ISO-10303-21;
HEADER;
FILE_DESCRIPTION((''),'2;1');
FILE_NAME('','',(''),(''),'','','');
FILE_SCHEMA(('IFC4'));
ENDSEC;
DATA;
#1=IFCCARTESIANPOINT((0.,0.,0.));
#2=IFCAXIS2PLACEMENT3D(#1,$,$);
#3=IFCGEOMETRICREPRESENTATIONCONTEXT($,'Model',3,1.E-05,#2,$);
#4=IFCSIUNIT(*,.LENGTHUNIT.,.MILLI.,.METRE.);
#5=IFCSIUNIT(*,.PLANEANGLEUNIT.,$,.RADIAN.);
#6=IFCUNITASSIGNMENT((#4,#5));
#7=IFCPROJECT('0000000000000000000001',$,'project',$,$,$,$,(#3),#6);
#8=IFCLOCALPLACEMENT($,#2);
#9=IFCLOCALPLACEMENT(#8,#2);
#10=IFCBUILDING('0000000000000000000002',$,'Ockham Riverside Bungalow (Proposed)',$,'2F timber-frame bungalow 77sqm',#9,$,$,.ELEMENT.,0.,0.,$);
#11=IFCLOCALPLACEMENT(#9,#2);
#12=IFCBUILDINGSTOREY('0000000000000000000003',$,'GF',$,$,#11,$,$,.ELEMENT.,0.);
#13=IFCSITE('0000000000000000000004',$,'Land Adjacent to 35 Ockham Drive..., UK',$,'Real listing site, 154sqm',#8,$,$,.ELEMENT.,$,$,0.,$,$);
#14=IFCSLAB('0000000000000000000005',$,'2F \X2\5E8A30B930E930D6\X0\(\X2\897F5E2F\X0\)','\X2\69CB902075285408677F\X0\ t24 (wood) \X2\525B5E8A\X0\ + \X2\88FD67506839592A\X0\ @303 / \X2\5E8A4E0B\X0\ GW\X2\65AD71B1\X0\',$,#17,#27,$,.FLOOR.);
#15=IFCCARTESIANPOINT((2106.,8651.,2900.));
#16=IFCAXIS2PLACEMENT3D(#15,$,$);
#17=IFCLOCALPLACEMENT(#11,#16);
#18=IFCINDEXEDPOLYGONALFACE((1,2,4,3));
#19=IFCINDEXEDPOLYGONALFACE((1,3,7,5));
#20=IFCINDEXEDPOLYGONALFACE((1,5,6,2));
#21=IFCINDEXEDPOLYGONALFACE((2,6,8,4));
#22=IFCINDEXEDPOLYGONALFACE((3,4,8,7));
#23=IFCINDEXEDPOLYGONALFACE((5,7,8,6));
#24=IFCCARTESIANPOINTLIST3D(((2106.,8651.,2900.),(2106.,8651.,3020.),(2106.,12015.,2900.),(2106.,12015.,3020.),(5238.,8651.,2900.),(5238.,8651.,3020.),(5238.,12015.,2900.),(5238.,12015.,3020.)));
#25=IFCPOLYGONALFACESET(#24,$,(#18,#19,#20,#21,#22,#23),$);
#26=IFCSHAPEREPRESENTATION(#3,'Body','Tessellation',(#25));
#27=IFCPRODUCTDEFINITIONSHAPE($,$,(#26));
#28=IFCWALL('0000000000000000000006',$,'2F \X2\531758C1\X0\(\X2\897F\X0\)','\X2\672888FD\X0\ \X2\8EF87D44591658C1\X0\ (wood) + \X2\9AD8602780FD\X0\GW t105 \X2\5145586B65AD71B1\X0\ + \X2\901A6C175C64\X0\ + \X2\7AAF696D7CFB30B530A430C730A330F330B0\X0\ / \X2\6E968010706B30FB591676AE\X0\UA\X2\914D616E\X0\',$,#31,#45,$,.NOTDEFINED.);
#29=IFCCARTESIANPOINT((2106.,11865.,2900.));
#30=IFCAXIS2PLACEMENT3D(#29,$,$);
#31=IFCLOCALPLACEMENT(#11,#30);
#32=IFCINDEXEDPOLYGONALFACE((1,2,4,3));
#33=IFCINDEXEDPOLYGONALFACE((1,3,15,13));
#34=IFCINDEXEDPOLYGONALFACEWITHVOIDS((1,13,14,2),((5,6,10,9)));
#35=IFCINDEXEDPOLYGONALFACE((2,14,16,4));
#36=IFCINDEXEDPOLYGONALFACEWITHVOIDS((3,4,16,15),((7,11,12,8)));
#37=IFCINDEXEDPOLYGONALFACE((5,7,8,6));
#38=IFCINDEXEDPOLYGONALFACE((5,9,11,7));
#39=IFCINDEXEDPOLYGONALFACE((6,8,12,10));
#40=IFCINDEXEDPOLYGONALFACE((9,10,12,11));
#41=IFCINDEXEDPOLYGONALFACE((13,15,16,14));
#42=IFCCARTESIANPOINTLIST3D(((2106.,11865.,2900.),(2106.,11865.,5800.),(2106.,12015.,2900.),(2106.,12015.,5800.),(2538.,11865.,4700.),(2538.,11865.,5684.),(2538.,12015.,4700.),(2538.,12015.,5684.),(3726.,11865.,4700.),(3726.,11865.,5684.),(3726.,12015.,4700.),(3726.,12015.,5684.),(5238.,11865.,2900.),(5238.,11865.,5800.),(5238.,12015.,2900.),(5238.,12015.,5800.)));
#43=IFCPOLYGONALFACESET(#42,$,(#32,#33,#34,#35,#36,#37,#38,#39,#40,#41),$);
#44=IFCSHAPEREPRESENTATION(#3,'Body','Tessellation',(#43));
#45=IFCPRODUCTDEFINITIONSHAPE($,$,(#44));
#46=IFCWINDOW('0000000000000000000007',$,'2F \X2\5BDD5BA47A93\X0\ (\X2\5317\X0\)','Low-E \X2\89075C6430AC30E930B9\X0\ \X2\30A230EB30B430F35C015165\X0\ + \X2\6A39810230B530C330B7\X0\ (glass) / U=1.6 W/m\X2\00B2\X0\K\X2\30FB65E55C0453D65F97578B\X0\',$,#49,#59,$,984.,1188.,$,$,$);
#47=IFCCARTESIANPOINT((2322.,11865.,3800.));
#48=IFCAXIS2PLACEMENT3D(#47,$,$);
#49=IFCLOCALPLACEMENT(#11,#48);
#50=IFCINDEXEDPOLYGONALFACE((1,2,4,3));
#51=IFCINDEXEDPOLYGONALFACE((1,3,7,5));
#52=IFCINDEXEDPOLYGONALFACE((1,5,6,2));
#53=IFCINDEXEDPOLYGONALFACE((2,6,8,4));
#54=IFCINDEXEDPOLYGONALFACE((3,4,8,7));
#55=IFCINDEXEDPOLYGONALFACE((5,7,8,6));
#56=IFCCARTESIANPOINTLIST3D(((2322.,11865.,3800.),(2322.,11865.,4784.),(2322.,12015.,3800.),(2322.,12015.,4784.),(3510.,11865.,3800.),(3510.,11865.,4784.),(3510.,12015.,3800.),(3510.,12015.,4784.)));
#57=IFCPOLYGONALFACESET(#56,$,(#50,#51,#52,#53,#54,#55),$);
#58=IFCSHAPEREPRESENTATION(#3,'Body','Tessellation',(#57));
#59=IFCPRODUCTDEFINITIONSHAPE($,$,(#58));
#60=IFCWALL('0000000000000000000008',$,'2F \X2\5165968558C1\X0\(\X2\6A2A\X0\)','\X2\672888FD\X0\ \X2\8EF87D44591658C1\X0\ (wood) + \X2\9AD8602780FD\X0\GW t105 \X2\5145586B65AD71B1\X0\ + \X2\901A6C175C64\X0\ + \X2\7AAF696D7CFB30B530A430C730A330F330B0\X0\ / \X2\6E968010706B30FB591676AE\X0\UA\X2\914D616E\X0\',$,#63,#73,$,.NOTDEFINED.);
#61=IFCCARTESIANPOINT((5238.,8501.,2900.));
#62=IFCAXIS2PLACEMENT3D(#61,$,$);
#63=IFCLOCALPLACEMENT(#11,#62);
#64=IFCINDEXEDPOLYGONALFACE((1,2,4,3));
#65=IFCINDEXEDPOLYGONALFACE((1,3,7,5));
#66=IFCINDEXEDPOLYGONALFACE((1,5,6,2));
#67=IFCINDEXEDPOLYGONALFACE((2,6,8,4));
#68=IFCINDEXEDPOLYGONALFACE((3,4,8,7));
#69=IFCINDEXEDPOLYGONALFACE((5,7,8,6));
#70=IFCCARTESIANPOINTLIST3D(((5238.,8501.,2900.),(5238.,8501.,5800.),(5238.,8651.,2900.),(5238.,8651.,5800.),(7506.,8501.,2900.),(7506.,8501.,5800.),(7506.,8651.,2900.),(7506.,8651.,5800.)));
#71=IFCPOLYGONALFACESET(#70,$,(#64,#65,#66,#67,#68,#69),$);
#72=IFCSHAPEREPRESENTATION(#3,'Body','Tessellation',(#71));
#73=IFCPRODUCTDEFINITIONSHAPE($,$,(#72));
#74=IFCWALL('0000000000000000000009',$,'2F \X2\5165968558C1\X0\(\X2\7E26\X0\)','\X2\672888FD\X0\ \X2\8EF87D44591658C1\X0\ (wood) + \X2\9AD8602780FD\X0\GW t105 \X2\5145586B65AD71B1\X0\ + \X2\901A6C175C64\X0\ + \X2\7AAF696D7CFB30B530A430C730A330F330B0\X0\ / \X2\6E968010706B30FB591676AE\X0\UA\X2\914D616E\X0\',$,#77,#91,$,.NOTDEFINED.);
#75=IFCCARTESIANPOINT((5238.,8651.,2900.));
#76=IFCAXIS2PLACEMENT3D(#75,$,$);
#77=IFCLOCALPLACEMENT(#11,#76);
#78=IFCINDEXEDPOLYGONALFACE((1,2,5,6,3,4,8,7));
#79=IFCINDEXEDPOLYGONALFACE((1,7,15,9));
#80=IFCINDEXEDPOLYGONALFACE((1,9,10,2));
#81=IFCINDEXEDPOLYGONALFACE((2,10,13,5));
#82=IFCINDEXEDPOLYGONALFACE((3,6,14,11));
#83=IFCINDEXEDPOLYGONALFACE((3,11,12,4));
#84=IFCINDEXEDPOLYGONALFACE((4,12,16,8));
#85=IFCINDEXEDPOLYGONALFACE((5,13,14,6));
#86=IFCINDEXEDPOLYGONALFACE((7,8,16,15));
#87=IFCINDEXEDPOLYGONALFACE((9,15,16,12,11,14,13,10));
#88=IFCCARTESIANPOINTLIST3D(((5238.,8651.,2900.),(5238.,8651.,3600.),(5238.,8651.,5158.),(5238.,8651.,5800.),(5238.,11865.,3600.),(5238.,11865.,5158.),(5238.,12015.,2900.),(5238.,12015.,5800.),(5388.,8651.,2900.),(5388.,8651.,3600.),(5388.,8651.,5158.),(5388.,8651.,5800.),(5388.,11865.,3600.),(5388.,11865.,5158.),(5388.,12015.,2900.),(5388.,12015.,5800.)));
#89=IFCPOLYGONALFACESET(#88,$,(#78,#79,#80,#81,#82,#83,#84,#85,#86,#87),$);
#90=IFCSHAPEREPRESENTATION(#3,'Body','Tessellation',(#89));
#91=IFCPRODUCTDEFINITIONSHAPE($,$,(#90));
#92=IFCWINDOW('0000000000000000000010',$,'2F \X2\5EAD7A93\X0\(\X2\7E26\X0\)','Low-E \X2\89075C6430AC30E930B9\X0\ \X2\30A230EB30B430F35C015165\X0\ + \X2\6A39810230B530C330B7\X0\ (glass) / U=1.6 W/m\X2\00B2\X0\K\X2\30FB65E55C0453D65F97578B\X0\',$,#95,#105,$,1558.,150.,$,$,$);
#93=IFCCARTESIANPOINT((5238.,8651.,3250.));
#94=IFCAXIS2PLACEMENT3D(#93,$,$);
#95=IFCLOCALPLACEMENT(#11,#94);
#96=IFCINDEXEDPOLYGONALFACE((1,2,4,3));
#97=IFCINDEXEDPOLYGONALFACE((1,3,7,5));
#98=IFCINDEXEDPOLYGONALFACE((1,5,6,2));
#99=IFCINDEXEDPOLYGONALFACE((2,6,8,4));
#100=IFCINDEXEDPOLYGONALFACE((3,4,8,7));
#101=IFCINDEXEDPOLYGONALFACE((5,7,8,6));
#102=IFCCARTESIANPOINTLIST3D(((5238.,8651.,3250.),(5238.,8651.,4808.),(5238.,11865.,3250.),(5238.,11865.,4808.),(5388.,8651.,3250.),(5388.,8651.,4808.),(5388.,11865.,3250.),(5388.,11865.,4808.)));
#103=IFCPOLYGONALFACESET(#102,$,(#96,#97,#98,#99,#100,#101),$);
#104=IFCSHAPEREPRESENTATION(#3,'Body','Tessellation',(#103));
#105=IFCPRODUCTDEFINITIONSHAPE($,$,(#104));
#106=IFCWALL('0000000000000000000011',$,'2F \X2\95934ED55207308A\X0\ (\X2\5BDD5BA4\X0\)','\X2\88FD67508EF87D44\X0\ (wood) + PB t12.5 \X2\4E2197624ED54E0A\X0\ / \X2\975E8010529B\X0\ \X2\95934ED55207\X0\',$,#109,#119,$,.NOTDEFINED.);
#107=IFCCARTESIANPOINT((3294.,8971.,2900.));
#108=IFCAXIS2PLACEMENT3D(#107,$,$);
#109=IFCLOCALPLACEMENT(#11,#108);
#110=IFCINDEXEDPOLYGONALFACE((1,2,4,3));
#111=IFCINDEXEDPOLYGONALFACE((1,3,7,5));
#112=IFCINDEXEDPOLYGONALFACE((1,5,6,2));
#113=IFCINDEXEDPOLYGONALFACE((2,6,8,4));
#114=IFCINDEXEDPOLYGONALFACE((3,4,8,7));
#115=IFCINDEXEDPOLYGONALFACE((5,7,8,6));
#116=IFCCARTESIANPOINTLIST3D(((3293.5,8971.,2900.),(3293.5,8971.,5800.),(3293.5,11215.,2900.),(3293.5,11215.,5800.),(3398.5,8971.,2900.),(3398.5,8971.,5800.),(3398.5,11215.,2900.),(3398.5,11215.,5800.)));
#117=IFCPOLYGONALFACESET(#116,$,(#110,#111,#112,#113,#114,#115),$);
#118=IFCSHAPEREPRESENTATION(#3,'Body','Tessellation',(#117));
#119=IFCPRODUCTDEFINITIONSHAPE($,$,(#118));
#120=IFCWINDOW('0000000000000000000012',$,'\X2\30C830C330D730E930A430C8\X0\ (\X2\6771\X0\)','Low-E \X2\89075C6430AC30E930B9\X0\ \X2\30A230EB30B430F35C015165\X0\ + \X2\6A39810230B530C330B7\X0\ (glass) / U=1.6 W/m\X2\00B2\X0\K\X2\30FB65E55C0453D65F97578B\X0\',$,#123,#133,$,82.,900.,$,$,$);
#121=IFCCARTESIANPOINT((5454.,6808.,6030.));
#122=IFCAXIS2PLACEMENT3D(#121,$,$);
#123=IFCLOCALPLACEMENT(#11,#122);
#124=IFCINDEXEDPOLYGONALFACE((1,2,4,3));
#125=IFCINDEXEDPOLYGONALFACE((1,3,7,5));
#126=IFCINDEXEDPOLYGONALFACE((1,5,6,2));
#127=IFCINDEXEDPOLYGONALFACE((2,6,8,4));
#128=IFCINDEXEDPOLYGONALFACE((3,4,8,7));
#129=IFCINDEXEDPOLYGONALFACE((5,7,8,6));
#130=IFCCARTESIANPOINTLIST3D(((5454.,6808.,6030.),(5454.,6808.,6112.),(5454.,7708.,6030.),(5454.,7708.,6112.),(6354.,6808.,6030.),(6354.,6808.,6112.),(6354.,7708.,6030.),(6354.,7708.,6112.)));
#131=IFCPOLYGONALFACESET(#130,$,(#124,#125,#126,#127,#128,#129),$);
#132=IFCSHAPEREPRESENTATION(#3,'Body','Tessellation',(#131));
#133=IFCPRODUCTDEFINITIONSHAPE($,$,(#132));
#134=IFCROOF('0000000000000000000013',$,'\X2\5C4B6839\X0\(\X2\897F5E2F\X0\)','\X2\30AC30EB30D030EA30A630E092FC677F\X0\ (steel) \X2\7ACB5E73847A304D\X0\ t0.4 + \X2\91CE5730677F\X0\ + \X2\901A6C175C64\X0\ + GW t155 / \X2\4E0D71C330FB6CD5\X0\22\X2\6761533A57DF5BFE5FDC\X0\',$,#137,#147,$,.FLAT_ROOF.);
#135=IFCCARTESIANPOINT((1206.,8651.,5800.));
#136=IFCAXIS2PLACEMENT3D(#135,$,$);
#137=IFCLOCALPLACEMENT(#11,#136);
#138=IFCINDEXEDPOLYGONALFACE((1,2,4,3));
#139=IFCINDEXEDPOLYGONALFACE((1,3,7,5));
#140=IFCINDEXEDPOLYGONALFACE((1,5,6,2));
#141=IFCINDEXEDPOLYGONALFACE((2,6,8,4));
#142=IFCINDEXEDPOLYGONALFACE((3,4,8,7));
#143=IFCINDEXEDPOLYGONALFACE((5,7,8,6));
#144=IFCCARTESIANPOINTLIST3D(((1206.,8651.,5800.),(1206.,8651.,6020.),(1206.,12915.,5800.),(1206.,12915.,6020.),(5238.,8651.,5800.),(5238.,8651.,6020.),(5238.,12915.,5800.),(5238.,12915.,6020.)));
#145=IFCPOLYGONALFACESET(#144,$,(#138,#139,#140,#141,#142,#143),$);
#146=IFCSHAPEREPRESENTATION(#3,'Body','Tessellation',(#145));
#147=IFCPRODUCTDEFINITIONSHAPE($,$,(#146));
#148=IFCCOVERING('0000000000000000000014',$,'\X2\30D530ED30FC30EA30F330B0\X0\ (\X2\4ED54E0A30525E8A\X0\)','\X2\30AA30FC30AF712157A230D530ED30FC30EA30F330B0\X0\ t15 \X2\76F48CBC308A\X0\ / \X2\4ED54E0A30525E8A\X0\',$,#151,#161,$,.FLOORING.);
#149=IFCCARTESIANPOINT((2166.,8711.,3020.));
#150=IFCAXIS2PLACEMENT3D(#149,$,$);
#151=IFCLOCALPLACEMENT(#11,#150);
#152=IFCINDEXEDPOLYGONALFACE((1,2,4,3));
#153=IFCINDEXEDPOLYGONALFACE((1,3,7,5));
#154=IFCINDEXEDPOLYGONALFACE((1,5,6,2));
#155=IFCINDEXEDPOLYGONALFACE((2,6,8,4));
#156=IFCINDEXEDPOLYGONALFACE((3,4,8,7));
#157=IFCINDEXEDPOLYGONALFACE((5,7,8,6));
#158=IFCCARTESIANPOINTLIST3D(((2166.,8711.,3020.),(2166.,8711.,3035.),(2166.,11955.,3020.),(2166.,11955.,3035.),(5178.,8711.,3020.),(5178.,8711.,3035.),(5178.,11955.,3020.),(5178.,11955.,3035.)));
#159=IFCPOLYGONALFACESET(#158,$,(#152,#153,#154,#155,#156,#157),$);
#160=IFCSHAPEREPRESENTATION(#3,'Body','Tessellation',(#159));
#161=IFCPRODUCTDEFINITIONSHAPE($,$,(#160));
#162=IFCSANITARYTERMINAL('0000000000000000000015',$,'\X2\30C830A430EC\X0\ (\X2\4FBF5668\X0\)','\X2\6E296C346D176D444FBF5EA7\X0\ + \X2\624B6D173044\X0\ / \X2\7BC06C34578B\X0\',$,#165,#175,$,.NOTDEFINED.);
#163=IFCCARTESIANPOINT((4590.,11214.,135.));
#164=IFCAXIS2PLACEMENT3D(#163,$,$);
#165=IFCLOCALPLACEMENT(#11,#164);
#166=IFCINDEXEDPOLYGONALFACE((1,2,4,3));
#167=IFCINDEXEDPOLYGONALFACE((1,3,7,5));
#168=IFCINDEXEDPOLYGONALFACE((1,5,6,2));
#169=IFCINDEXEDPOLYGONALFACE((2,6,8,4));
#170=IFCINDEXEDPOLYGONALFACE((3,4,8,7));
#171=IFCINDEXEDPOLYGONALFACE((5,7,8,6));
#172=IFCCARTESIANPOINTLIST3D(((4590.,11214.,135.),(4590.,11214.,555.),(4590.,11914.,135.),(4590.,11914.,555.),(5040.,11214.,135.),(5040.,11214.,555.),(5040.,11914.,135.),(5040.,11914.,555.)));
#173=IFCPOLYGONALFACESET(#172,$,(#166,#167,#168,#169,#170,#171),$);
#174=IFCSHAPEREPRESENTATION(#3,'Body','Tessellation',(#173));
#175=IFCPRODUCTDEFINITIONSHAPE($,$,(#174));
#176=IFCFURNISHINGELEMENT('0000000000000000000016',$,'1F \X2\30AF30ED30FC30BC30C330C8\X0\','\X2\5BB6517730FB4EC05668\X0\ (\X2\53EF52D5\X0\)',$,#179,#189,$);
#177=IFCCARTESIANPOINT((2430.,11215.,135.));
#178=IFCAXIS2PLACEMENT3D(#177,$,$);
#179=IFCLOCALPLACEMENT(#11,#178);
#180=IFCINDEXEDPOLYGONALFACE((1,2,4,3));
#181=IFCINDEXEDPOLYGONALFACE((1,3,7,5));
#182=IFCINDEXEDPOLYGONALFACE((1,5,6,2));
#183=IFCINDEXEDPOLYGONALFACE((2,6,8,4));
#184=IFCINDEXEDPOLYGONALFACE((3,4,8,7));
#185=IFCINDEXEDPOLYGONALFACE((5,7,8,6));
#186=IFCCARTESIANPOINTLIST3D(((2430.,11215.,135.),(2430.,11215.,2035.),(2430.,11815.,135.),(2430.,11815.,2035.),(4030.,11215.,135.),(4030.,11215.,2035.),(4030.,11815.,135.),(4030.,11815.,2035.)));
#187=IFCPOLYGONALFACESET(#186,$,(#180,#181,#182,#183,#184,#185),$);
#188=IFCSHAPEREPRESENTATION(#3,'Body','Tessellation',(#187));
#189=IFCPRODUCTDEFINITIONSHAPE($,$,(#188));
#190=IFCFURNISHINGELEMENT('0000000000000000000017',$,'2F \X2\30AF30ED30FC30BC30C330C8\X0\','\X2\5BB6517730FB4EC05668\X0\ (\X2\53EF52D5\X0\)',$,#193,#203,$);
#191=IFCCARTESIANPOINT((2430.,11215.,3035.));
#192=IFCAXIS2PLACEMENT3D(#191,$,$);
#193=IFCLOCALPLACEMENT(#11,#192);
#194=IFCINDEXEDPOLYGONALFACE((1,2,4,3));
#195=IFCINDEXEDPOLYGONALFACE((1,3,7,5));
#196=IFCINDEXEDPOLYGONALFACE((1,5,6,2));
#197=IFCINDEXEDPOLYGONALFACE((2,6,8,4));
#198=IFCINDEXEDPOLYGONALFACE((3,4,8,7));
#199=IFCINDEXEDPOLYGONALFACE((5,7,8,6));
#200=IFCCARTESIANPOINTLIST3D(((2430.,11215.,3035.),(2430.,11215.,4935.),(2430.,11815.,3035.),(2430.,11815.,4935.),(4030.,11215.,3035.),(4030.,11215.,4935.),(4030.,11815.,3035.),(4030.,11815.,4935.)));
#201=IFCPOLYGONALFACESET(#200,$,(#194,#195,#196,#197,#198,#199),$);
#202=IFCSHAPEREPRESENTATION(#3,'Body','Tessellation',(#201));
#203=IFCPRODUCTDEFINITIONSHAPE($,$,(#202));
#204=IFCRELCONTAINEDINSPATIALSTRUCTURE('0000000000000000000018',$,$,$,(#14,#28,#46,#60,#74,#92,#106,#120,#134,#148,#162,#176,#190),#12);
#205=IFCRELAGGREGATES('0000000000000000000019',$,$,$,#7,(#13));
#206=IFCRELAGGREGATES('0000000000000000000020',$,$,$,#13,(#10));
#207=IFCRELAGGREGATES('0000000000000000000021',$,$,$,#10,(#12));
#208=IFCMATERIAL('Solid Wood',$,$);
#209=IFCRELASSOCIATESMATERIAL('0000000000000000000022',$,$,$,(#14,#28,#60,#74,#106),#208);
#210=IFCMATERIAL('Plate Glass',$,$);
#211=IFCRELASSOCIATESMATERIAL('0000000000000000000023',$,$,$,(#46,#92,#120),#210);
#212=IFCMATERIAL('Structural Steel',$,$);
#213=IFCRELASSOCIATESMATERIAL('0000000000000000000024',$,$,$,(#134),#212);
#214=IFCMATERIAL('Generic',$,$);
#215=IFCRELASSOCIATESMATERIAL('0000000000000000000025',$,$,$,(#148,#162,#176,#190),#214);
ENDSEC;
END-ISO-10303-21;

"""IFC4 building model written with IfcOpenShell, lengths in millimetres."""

from ifc_helpers import new_model, si_unit, frame, frame_2d, origin, place, context, project, spatial, rectangle, extrude, material, element, fill, save


model = new_model("IFC4")

# Units and contexts
model_context = context("Model", 3, precision=1e-05, world=origin())
ifc_project = project(units=[si_unit("LENGTHUNIT", "METRE", prefix="MILLI"), si_unit("PLANEANGLEUNIT", "RADIAN")], contexts=[model_context])

# Site, building, storey
site_placement = place(None, origin())
site = spatial("IfcSite", under=ifc_project, at=site_placement, Name="Land Adjacent to 35 Ockham Drive..., UK", ObjectType="Real listing site, 154sqm", CompositionType="ELEMENT", RefElevation=0.0)
building_placement = place(site_placement, origin())
building = spatial("IfcBuilding", under=site, at=building_placement, Name="Ockham Riverside Bungalow (Proposed)", ObjectType="2F timber-frame bungalow 77sqm", CompositionType="ELEMENT", ElevationOfRefHeight=0.0, ElevationOfTerrain=0.0)
storey_placement = place(building_placement, origin())
storey = spatial("IfcBuildingStorey", under=building, at=storey_placement, Name="GF", CompositionType="ELEMENT", Elevation=0.0)

# Slab
ifc_material_1 = material(Name="Solid Wood")
slab_placement = place(storey_placement, frame((2106.0, 8651.0, 2900.0)))
element("IfcSlab", 1, at=slab_placement, inside=storey, material=ifc_material_1, Name="2F 床スラブ(西帯)", Description="構造用合板 t24 (wood) 剛床 + 製材根太 @303 / 床下 GW断熱", PredefinedType="FLOOR", context=model_context, shape_type="SweptSolid", body=[
    extrude(rectangle(XDim=3132.0, YDim=3364.0, at=frame_2d((1566.0, 1682.0))), frame((2106.0, 8651.0, 2900.0)), (0.0, 0.0, 1.0), 120.0),
])

# Wall, opening, window
wall_1_placement = place(storey_placement, frame((2106.0, 11865.0, 2900.0)))
wall_1 = element("IfcWall", 2, at=wall_1_placement, inside=storey, material=ifc_material_1, Name="2F 北壁(西)", Description="木製 軸組外壁 (wood) + 高性能GW t105 充填断熱 + 通気層 + 窯業系サイディング / 準耐火・外皮UA配慮", PredefinedType="NOTDEFINED", context=model_context, shape_type="SweptSolid", body=[
    extrude(rectangle(XDim=3132.0, YDim=150.0, at=frame_2d((1566.0, 75.0))), frame((2106.0, 11865.0, 2900.0)), (0.0, 0.0, 1.0), 2900.0),
])
opening_1_placement = place(storey_placement, frame((2322.0, 11865.0, 3800.0)))
opening_1 = element("IfcOpeningElement", 3, at=opening_1_placement, cuts=wall_1, PredefinedType="NOTDEFINED", context=model_context, shape_type="SweptSolid", body=[
    extrude(rectangle(XDim=1188.0, YDim=150.0, at=frame_2d((594.0, 75.0))), frame((2322.0, 11865.0, 3800.0)), (0.0, 0.0, 1.0), 984.0),
])
ifc_material_2 = material(Name="Plate Glass")
window_1_placement = place(storey_placement, frame((2322.0, 11865.0, 3800.0)))
window_1 = element("IfcWindow", 4, at=window_1_placement, inside=storey, material=ifc_material_2, Name="2F 寝室窓 (北)", Description="Low-E 複層ガラス アルゴン封入 + 樹脂サッシ (glass) / U=1.6 W/m²K・日射取得型", OverallHeight=984.0, OverallWidth=1188.0, context=model_context, shape_type="SweptSolid", body=[
    extrude(rectangle(XDim=1188.0, YDim=150.0, at=frame_2d((594.0, 75.0))), frame((2322.0, 11865.0, 3800.0)), (0.0, 0.0, 1.0), 984.0),
])
fill(opening_1, window_1)

# Wall
wall_2_placement = place(storey_placement, frame((5238.0, 8501.0, 2900.0)))
element("IfcWall", 5, at=wall_2_placement, inside=storey, material=ifc_material_1, Name="2F 入隅壁(横)", Description="木製 軸組外壁 (wood) + 高性能GW t105 充填断熱 + 通気層 + 窯業系サイディング / 準耐火・外皮UA配慮", PredefinedType="NOTDEFINED", context=model_context, shape_type="SweptSolid", body=[
    extrude(rectangle(XDim=2268.0, YDim=150.0, at=frame_2d((1134.0, 75.0))), frame((5238.0, 8501.0, 2900.0)), (0.0, 0.0, 1.0), 2900.0),
])

# Wall, opening, window
wall_3_placement = place(storey_placement, frame((5238.0, 8651.0, 2900.0)))
wall_3 = element("IfcWall", 6, at=wall_3_placement, inside=storey, material=ifc_material_1, Name="2F 入隅壁(縦)", Description="木製 軸組外壁 (wood) + 高性能GW t105 充填断熱 + 通気層 + 窯業系サイディング / 準耐火・外皮UA配慮", PredefinedType="NOTDEFINED", context=model_context, shape_type="SweptSolid", body=[
    extrude(rectangle(XDim=150.0, YDim=3364.0, at=frame_2d((75.0, 1682.0))), frame((5238.0, 8651.0, 2900.0)), (0.0, 0.0, 1.0), 2900.0),
])
opening_2_placement = place(storey_placement, frame((5238.0, 8651.0, 3250.0)))
opening_2 = element("IfcOpeningElement", 7, at=opening_2_placement, cuts=wall_3, PredefinedType="NOTDEFINED", context=model_context, shape_type="SweptSolid", body=[
    extrude(rectangle(XDim=150.0, YDim=3214.0, at=frame_2d((75.0, 1607.0))), frame((5238.0, 8651.0, 3250.0)), (0.0, 0.0, 1.0), 1558.0),
])
window_2_placement = place(storey_placement, frame((5238.0, 8651.0, 3250.0)))
window_2 = element("IfcWindow", 8, at=window_2_placement, inside=storey, material=ifc_material_2, Name="2F 庭窓(縦)", Description="Low-E 複層ガラス アルゴン封入 + 樹脂サッシ (glass) / U=1.6 W/m²K・日射取得型", OverallHeight=1558.0, OverallWidth=150.0, context=model_context, shape_type="SweptSolid", body=[
    extrude(rectangle(XDim=150.0, YDim=3214.0, at=frame_2d((75.0, 1607.0))), frame((5238.0, 8651.0, 3250.0)), (0.0, 0.0, 1.0), 1558.0),
])
fill(opening_2, window_2)

# Wall
wall_4_placement = place(storey_placement, frame((3294.0, 8971.0, 2900.0)))
element("IfcWall", 9, at=wall_4_placement, inside=storey, material=ifc_material_1, Name="2F 間仕切り (寝室)", Description="製材軸組 (wood) + PB t12.5 両面仕上 / 非耐力 間仕切", PredefinedType="NOTDEFINED", context=model_context, shape_type="SweptSolid", body=[
    extrude(rectangle(XDim=105.0, YDim=2244.0, at=frame_2d((52.0, 1122.0))), frame((3294.0, 8971.0, 2900.0)), (0.0, 0.0, 1.0), 2900.0),
])

# Window
window_3_placement = place(storey_placement, frame((5454.0, 6808.0, 6030.0)))
element("IfcWindow", 10, at=window_3_placement, inside=storey, material=ifc_material_2, Name="トップライト (東)", Description="Low-E 複層ガラス アルゴン封入 + 樹脂サッシ (glass) / U=1.6 W/m²K・日射取得型", OverallHeight=82.0, OverallWidth=900.0, context=model_context, shape_type="SweptSolid", body=[
    extrude(rectangle(XDim=900.0, YDim=900.0, at=frame_2d((450.0, 450.0))), frame((5454.0, 6808.0, 6030.0)), (0.0, 0.0, 1.0), 82.0),
])

# Roof
ifc_material_3 = material(Name="Structural Steel")
for number, where, name in (
    (11, (1206.0, 8651.0, 5800.0), "屋根(西帯)"),
):
    element("IfcRoof", number, at=place(storey_placement, frame(where)), inside=storey, material=ifc_material_3, Name=name, Description="ガルバリウム鋼板 (steel) 立平葺き t0.4 + 野地板 + 通気層 + GW t155 / 不燃・法22条区域対応", PredefinedType="FLAT_ROOF", context=model_context, shape_type="SweptSolid", body=[
        extrude(rectangle(XDim=4032.0, YDim=4264.0, at=frame_2d((2016.0, 2132.0))), frame((1206.0, 8651.0, 5800.0)), (0.0, 0.0, 1.0), 220.0),
    ])

# Covering
ifc_material_4 = material(Name="Generic")
covering_placement = place(storey_placement, frame((2166.0, 8711.0, 3020.0)))
element("IfcCovering", 12, at=covering_placement, inside=storey, material=ifc_material_4, Name="フローリング (仕上げ床)", Description="オーク無垢フローリング t15 直貼り / 仕上げ床", PredefinedType="FLOORING", context=model_context, shape_type="SweptSolid", body=[
    extrude(rectangle(XDim=3012.0, YDim=3244.0, at=frame_2d((1506.0, 1622.0))), frame((2166.0, 8711.0, 3020.0)), (0.0, 0.0, 1.0), 15.0),
])

# Sanitary terminal
sanitary_terminal_placement = place(storey_placement, frame((4590.0, 11214.0, 135.0)))
element("IfcSanitaryTerminal", 13, at=sanitary_terminal_placement, inside=storey, material=ifc_material_4, Name="トイレ (便器)", Description="温水洗浄便座 + 手洗い / 節水型", PredefinedType="NOTDEFINED", context=model_context, shape_type="SweptSolid", body=[
    extrude(rectangle(XDim=450.0, YDim=700.0, at=frame_2d((225.0, 350.0))), frame((4590.0, 11214.0, 135.0)), (0.0, 0.0, 1.0), 420.0),
])

# Furnishing elements
furnishing_1_placement = place(storey_placement, frame((2430.0, 11215.0, 135.0)))
element("IfcFurnishingElement", 14, at=furnishing_1_placement, inside=storey, material=ifc_material_4, Name="1F クローゼット", Description="家具・什器 (可動)", context=model_context, shape_type="SweptSolid", body=[
    extrude(rectangle(XDim=1600.0, YDim=600.0, at=frame_2d((800.0, 300.0))), frame((2430.0, 11215.0, 135.0)), (0.0, 0.0, 1.0), 1900.0),
])
furnishing_2_placement = place(storey_placement, frame((2430.0, 11215.0, 3035.0)))
element("IfcFurnishingElement", 15, at=furnishing_2_placement, inside=storey, material=ifc_material_4, Name="2F クローゼット", Description="家具・什器 (可動)", context=model_context, shape_type="SweptSolid", body=[
    extrude(rectangle(XDim=1600.0, YDim=600.0, at=frame_2d((800.0, 300.0))), frame((2430.0, 11215.0, 3035.0)), (0.0, 0.0, 1.0), 1900.0),
])

save(model, "model.ifc")
